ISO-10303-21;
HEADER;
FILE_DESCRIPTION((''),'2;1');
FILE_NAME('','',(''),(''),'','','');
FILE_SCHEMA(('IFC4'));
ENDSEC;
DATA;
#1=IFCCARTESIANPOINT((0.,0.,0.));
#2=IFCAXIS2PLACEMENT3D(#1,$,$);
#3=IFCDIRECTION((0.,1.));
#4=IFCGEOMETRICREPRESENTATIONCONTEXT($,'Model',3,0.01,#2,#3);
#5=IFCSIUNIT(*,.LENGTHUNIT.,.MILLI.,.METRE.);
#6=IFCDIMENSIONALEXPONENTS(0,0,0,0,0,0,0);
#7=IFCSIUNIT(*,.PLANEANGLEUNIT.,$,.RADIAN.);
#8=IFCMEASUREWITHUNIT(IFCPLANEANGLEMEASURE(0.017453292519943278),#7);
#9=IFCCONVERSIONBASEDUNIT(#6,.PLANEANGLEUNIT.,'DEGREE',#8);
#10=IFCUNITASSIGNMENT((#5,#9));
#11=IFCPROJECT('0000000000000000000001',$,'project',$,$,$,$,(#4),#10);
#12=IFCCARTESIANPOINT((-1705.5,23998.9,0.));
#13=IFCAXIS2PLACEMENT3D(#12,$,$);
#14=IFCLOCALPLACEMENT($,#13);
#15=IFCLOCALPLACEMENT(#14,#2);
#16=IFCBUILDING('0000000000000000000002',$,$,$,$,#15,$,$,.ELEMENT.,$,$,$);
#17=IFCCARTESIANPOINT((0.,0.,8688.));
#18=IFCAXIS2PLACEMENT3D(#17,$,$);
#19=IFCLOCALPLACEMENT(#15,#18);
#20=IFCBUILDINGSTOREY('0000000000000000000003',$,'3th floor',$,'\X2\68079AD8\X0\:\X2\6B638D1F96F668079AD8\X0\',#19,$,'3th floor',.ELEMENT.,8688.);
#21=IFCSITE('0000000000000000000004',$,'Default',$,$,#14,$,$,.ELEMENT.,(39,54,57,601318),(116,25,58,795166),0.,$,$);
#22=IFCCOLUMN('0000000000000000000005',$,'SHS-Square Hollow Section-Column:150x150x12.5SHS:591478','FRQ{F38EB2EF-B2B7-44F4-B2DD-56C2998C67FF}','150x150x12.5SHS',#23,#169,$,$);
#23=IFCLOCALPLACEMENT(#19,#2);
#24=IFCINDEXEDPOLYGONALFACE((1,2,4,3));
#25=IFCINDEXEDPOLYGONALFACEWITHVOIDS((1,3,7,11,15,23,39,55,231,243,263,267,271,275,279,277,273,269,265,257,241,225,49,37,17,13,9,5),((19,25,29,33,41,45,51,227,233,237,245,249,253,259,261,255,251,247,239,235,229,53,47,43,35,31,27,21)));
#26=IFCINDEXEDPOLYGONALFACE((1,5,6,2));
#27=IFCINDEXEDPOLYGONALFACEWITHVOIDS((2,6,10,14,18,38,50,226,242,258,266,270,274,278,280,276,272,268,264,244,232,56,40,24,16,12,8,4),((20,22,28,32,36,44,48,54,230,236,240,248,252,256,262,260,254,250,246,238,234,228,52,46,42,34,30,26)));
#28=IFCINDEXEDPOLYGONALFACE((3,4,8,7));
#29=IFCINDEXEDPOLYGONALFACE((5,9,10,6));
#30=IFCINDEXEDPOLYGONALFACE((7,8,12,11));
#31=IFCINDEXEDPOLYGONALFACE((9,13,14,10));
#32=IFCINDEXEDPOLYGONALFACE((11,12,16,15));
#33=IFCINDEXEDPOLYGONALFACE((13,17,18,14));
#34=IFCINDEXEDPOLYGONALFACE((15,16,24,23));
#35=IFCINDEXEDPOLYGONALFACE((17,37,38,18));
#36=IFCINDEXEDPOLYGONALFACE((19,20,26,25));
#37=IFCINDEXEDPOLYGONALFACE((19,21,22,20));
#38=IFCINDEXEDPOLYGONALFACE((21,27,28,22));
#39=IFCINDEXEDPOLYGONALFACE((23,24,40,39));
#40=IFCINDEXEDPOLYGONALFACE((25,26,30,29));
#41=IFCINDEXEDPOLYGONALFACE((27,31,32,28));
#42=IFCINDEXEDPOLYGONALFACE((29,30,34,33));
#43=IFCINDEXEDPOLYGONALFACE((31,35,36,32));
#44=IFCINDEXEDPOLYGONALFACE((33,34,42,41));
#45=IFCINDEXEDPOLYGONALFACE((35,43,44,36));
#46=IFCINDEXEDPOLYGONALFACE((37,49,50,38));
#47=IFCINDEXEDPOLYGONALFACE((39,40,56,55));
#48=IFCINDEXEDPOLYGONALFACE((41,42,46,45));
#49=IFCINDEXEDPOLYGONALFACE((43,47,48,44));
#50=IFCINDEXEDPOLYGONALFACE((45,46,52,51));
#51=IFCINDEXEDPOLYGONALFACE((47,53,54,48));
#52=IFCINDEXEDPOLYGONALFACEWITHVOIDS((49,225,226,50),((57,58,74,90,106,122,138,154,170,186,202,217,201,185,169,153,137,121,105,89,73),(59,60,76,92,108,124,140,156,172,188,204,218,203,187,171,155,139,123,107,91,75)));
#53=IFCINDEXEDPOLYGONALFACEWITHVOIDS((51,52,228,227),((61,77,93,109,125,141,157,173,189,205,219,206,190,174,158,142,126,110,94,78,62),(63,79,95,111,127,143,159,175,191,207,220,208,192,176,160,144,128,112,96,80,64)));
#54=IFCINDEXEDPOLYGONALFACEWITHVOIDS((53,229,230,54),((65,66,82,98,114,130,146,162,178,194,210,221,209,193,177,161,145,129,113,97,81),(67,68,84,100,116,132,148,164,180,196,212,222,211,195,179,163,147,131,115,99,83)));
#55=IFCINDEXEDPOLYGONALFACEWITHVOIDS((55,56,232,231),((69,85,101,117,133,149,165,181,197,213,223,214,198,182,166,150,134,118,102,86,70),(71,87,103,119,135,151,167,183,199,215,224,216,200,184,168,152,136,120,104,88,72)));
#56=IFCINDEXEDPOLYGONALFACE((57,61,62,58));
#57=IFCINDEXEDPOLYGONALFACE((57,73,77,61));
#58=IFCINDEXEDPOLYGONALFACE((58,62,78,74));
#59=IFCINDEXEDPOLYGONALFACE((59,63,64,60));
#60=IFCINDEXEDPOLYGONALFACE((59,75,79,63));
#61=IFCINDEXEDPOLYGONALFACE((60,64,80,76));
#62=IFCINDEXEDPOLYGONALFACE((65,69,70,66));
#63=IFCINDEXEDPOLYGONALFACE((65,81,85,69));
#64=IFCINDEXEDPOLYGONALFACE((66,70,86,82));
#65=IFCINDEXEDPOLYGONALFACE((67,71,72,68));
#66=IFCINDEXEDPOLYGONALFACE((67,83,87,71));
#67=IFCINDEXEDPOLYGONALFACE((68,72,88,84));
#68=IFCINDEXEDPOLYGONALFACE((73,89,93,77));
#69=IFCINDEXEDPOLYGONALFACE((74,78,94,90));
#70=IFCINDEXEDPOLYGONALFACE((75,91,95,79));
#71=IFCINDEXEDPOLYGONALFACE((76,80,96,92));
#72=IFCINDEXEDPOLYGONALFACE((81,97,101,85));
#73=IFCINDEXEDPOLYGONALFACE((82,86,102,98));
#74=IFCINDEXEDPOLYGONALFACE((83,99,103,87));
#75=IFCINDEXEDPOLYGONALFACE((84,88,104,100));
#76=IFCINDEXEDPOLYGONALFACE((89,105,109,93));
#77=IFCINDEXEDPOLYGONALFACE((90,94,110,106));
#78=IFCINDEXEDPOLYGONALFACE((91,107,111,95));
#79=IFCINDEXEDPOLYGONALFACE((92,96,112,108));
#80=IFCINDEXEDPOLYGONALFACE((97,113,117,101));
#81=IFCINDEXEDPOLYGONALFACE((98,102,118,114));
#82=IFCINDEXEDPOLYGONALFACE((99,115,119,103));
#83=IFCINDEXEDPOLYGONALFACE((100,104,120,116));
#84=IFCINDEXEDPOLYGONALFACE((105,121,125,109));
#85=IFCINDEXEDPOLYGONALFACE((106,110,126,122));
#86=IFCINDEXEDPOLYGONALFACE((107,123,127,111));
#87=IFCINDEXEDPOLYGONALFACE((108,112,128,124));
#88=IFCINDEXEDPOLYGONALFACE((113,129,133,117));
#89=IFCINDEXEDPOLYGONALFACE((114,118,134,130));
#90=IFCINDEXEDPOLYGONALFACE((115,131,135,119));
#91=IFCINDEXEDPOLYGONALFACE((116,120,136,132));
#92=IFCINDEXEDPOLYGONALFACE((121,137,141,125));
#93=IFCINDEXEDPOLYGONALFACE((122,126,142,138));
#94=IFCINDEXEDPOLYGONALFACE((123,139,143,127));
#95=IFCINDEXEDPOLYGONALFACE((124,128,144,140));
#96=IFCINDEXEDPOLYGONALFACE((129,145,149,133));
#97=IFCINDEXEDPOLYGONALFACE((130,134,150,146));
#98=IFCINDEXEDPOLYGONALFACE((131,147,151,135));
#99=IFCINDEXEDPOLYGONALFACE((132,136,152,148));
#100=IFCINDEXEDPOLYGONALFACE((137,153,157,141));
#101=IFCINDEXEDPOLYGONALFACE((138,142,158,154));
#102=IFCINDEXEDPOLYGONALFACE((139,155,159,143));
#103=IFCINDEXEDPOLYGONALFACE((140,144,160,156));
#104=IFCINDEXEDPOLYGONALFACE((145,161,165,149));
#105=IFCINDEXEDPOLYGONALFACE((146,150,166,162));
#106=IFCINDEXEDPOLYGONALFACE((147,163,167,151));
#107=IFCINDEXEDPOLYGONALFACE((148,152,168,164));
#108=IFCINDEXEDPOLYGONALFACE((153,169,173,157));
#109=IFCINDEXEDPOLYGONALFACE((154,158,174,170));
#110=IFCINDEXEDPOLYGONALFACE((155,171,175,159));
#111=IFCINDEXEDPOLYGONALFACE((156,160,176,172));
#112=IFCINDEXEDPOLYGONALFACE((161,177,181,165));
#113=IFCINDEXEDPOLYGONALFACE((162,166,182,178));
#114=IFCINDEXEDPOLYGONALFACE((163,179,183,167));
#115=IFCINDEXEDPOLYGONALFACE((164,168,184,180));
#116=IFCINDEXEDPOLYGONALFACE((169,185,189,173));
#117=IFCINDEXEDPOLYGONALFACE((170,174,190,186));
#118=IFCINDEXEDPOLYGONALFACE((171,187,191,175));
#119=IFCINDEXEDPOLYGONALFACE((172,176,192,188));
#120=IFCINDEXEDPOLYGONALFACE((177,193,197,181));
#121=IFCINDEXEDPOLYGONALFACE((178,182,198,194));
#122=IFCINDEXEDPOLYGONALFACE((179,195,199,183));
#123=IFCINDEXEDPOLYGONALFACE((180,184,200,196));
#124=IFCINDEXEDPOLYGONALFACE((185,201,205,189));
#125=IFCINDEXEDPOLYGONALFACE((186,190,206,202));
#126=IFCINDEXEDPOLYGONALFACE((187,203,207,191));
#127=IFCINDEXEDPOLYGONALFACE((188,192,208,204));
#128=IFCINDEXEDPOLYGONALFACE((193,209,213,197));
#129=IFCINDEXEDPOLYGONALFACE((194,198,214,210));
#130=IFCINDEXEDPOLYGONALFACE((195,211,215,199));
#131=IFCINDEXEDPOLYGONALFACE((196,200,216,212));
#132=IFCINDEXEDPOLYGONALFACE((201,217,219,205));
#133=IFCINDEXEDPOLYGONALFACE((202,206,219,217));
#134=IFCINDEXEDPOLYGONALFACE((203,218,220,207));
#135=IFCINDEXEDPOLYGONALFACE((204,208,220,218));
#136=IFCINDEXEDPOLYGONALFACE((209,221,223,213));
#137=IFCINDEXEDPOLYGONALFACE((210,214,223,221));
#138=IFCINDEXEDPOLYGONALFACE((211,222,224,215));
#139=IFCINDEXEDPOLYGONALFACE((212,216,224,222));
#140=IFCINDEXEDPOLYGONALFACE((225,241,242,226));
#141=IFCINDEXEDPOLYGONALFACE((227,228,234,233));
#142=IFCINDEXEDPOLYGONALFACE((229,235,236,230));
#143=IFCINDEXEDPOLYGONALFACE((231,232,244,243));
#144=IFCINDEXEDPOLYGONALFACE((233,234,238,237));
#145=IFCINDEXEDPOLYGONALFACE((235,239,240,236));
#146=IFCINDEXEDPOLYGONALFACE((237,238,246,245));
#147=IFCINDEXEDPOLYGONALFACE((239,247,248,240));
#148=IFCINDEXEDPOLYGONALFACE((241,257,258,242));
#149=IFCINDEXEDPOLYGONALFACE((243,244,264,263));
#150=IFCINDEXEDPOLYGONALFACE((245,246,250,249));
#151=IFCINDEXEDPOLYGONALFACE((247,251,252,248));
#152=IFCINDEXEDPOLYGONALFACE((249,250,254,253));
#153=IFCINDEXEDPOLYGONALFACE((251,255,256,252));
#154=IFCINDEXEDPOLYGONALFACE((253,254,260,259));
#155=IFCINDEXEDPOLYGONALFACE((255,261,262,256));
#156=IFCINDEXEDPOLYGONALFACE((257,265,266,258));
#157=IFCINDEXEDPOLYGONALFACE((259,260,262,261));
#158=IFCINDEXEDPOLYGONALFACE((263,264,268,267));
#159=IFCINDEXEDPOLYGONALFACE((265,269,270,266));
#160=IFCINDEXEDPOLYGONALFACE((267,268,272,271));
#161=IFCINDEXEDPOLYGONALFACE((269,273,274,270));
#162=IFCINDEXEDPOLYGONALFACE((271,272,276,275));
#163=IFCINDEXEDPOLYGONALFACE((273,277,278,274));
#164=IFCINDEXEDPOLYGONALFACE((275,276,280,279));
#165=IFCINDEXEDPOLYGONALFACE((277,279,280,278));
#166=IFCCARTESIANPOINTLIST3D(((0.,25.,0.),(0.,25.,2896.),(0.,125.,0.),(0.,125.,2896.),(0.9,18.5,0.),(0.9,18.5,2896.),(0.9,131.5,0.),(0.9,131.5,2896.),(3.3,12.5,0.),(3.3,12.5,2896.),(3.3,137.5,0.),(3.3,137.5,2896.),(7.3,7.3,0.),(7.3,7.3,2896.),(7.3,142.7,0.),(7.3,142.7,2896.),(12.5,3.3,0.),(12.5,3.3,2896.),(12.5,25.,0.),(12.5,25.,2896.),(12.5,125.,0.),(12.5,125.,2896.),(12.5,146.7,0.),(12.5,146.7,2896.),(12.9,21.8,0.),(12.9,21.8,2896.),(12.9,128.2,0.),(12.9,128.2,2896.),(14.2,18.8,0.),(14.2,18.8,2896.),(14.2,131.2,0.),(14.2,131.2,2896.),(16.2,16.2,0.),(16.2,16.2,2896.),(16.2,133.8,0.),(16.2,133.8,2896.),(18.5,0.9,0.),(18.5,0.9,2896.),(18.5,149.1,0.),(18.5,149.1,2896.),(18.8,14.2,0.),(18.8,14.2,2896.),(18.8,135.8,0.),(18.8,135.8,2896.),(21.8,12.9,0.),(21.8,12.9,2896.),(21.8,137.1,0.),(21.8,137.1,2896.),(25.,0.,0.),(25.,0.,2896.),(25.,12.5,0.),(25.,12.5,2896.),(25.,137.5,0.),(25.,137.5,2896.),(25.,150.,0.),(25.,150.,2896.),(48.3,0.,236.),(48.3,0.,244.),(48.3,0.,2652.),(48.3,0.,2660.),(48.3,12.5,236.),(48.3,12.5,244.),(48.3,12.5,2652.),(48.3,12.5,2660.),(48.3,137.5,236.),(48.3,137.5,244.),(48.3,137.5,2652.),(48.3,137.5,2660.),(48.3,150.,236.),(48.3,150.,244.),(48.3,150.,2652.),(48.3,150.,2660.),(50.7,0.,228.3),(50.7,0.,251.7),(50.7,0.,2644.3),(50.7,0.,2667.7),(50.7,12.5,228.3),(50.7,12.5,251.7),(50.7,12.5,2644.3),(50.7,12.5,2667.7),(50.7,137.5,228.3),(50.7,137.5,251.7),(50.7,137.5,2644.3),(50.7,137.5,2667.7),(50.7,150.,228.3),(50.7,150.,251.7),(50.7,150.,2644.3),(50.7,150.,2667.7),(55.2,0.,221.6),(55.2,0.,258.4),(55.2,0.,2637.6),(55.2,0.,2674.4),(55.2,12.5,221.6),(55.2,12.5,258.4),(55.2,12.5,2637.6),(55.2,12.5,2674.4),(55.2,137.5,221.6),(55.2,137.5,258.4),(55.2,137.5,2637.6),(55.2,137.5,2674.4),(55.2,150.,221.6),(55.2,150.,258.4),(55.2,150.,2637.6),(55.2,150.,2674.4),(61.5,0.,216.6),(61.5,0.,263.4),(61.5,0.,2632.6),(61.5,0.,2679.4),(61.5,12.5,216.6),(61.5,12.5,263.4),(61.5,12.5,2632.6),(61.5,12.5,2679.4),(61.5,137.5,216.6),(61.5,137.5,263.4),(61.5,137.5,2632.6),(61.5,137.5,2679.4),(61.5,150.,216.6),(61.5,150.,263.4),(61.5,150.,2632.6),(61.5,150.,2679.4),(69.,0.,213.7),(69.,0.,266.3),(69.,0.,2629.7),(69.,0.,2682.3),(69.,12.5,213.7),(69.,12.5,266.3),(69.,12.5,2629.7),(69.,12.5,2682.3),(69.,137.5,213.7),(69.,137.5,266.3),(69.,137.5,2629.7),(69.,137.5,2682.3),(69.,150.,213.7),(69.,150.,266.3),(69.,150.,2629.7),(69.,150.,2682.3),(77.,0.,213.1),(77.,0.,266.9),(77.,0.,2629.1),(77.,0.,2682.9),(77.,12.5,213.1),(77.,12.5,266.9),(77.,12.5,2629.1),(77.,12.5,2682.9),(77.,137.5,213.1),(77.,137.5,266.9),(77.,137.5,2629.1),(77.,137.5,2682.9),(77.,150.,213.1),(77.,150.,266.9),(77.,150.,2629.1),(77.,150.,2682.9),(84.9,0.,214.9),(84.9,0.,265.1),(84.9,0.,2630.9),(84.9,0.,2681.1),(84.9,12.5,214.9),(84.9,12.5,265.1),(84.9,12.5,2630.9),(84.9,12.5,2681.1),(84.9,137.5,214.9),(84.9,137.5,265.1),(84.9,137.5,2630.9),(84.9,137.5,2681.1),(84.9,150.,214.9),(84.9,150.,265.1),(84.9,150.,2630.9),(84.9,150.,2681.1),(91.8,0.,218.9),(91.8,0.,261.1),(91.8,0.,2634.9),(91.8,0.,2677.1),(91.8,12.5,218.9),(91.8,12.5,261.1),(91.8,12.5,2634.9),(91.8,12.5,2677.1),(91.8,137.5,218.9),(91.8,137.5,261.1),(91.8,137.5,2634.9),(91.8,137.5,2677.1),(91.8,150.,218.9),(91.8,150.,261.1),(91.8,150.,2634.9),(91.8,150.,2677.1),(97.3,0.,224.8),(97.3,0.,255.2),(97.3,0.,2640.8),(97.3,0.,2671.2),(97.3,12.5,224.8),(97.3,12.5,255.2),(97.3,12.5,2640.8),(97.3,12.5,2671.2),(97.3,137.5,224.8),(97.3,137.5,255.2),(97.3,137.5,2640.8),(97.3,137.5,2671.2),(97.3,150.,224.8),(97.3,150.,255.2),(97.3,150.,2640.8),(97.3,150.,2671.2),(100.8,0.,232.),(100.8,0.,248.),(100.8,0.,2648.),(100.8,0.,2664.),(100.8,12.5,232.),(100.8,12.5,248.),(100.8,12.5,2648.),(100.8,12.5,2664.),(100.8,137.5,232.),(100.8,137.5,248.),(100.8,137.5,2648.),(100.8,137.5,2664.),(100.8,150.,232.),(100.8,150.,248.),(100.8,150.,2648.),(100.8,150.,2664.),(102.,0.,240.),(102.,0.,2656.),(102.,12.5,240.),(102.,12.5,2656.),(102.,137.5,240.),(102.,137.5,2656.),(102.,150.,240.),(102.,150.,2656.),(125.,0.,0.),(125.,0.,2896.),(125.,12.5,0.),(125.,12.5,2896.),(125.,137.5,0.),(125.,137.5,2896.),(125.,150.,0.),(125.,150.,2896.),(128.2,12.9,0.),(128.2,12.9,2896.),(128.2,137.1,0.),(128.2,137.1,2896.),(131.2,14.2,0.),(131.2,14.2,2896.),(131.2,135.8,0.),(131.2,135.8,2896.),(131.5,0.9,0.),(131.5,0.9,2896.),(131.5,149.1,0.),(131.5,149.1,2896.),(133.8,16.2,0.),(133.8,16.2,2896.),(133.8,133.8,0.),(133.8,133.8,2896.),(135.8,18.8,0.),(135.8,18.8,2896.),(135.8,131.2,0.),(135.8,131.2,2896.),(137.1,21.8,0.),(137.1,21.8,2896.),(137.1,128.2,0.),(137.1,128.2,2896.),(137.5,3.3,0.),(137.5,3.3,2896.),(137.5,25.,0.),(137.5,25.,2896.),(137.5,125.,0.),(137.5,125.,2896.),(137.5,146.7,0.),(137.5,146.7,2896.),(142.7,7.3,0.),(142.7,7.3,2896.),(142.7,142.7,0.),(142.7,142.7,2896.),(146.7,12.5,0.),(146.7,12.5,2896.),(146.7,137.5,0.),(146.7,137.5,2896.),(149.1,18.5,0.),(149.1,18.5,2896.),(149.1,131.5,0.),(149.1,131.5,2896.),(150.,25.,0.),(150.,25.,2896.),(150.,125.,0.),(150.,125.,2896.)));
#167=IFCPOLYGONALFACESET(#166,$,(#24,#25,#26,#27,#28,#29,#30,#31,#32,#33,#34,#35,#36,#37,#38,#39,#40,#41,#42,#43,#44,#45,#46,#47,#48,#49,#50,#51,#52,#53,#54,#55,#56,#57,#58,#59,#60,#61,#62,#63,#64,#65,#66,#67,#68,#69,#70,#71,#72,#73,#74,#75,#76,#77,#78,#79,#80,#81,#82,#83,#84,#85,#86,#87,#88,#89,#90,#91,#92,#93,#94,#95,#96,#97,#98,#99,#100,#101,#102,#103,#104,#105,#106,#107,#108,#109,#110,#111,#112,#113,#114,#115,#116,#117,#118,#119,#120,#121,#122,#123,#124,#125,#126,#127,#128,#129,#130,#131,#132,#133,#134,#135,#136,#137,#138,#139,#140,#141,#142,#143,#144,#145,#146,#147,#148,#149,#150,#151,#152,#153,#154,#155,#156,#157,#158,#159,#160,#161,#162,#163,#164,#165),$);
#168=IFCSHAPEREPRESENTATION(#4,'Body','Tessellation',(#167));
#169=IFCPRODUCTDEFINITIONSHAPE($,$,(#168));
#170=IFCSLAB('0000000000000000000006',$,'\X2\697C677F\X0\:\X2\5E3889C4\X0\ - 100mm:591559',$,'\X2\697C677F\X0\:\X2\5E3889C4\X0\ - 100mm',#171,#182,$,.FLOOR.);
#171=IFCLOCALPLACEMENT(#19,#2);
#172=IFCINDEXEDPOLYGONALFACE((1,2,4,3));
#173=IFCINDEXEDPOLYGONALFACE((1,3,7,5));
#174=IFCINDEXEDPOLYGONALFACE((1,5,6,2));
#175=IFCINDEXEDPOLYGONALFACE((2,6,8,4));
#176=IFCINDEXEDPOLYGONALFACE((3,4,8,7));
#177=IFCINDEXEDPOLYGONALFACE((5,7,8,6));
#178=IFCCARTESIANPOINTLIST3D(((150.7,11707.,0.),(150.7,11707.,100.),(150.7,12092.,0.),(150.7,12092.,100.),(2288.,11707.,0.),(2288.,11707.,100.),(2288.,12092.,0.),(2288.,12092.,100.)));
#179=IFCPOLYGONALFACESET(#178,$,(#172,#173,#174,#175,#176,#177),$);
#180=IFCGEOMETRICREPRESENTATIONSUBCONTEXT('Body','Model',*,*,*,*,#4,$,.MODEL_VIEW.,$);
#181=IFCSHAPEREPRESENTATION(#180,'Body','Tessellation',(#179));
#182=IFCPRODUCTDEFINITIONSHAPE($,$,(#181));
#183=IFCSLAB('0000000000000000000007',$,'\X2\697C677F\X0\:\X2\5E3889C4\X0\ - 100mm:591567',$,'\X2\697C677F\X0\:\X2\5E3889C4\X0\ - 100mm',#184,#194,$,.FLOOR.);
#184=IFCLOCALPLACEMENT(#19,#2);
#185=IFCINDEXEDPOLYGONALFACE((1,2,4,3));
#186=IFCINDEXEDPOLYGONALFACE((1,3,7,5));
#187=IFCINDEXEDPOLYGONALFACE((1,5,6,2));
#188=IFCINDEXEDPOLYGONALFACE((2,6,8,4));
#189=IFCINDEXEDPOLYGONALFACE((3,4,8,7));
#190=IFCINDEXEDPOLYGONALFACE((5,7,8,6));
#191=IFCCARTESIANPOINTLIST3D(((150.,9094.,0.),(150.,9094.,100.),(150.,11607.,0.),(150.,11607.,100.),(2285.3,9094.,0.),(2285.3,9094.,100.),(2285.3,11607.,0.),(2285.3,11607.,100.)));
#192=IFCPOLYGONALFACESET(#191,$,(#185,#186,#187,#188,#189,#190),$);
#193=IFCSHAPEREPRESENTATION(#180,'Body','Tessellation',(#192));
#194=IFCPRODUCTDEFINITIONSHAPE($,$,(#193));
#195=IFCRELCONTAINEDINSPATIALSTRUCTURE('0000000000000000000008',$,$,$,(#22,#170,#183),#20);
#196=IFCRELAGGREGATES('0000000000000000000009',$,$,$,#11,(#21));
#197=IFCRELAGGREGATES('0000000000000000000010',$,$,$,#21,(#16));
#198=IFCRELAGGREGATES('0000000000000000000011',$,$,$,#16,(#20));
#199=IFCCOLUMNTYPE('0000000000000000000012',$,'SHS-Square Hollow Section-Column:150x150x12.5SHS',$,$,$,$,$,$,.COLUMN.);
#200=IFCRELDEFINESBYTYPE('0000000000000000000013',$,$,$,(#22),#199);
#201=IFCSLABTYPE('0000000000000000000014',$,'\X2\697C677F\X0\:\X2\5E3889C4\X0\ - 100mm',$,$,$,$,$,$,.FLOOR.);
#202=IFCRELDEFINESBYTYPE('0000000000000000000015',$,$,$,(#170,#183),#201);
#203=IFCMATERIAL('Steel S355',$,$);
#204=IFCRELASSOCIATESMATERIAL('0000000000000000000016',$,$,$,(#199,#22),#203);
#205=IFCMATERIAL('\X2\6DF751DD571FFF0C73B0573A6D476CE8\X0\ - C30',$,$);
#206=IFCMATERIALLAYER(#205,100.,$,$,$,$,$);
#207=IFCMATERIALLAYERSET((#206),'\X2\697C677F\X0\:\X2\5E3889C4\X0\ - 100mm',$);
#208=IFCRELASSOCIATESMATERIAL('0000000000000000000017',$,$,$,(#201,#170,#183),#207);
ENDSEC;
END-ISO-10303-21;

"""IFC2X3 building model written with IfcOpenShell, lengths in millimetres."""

from ifc_helpers import new_model, entity, si_unit, converted_unit, direction, frame, frame_2d, origin, origin_2d, origin_2d_with_axis, place, context, subcontext, project, spatial, circle_curve, rectangle, hollow_rectangle, outline, extrude, material, layer, layer_set, layer_usage, type_object, element, save


model = new_model("IFC2X3")

# Units and contexts
model_context = context("Model", 3, precision=0.01, world=origin(), true_north=direction((0.0, 1.0)))
body_context = subcontext(model_context, "Body", "Model", "MODEL_VIEW")
ifc_project = project(units=[si_unit("LENGTHUNIT", "METRE", prefix="MILLI"), converted_unit("PLANEANGLEUNIT", "DEGREE", entity("IfcPlaneAngleMeasure", 0.017453292519943278), si_unit("PLANEANGLEUNIT", "RADIAN"), dimensions=[0, 0, 0, 0, 0, 0, 0])], contexts=[model_context])

# Site, building, storey
site_placement = place(None, frame((-1705.5, 23998.9, 0.0)))
site = spatial("IfcSite", under=ifc_project, at=site_placement, Name="Default", CompositionType="ELEMENT", RefLatitude=(39, 54, 57, 601318), RefLongitude=(116, 25, 58, 795166), RefElevation=0.0)
building_placement = place(site_placement, origin())
building = spatial("IfcBuilding", under=site, at=building_placement, CompositionType="ELEMENT")
storey_placement = place(building_placement, frame((0.0, 0.0, 8688.0)))
storey = spatial("IfcBuildingStorey", under=building, at=storey_placement, Name="3th floor", ObjectType="标高:正负零标高", LongName="3th floor", CompositionType="ELEMENT", Elevation=8688.0)

# Shared definitions
ifc_material_1 = material(Name="Steel S355")

# Column, openings
column_type_1 = type_object("IfcColumnType", Name="SHS-Square Hollow Section-Column:150x150x12.5SHS", PredefinedType="COLUMN", material=ifc_material_1)
column_1_placement = place(storey_placement, frame((75.0, 75.0, 2896.0), z_axis=(0.0, 0.0, 1.0), x_axis=(0.0, -1.0, 0.0)))
column_1 = element("IfcColumn", 1, at=column_1_placement, inside=storey, type_object=column_type_1, material=ifc_material_1, Name="SHS-Square Hollow Section-Column:150x150x12.5SHS:591478", Description="FRQ{F38EB2EF-B2B7-44F4-B2DD-56C2998C67FF}", ObjectType="150x150x12.5SHS", context=model_context, shape_type="SweptSolid", body=[
    extrude(hollow_rectangle(XDim=150.0, YDim=150.0, WallThickness=12.5, InnerFilletRadius=12.5, OuterFilletRadius=25.0, at=origin_2d()), origin(), (0.0, 0.0, -1.0), 2896.0),
])
opening_1_placement = place(column_1_placement, frame((-175.1, 0.0, -2896.0), z_axis=(1.0, 0.0, 0.0), x_axis=(0.0, 1.0, 0.0)))
element("IfcOpeningElement", 2, at=opening_1_placement, cuts=column_1, ObjectType="Opening", context=model_context, shape_type="SweptSolid", body=[
    extrude(outline(circle_curve(frame_2d((0.0, 240.0), x_axis=(1.0, 0.0)), 27.0)), origin(), (0.0, 0.0, 1.0), 350.2),
])
opening_2_placement = place(column_1_placement, frame((-175.1, 0.0, 0.0), z_axis=(1.0, 0.0, 0.0), x_axis=(0.0, 1.0, 0.0)))
element("IfcOpeningElement", 3, at=opening_2_placement, cuts=column_1, ObjectType="Opening", context=model_context, shape_type="SweptSolid", body=[
    extrude(outline(circle_curve(frame_2d((0.0, -240.0), x_axis=(1.0, 0.0)), 27.0)), origin(), (0.0, 0.0, 1.0), 350.2),
])

# Slabs
ifc_material_2 = material(Name="混凝土，现场浇注 - C30")
ifc_layer_1 = layer(ifc_material_2, 100.0)
ifc_layer_set_1 = layer_set([ifc_layer_1], Name="楼板:常规 - 100mm")
ifc_layer_usage_1 = layer_usage(ifc_layer_set_1, "AXIS3", "POSITIVE", 0.0)
slab_type = type_object("IfcSlabType", Name="楼板:常规 - 100mm", PredefinedType="FLOOR", material=ifc_layer_set_1)
slab_1_placement = place(storey_placement, origin())
element("IfcSlab", 4, at=slab_1_placement, inside=storey, type_object=slab_type, material=ifc_layer_usage_1, Name="楼板:常规 - 100mm:591559", ObjectType="楼板:常规 - 100mm", PredefinedType="FLOOR", context=body_context, shape_type="SweptSolid", body=[
    extrude(rectangle(XDim=385.0, YDim=2137.3, at=origin_2d_with_axis()), frame((1219.3, 11899.5, 100.0), z_axis=(0.0, 0.0, -1.0), x_axis=(0.0, 1.0, 0.0)), (0.0, 0.0, 1.0), 100.0),
])
ifc_layer_usage_2 = layer_usage(ifc_layer_set_1, "AXIS3", "POSITIVE", 0.0)
slab_2_placement = place(storey_placement, origin())
element("IfcSlab", 5, at=slab_2_placement, inside=storey, type_object=slab_type, material=ifc_layer_usage_2, Name="楼板:常规 - 100mm:591567", ObjectType="楼板:常规 - 100mm", PredefinedType="FLOOR", context=body_context, shape_type="SweptSolid", body=[
    extrude(rectangle(XDim=2513.0, YDim=2135.3, at=frame_2d((0.0, 0.0), x_axis=(1.0, 0.0))), frame((1217.6, 10350.5, 100.0), z_axis=(0.0, 0.0, -1.0), x_axis=(0.0, 1.0, 0.0)), (0.0, 0.0, 1.0), 100.0),
])

save(model, "model.ifc")
